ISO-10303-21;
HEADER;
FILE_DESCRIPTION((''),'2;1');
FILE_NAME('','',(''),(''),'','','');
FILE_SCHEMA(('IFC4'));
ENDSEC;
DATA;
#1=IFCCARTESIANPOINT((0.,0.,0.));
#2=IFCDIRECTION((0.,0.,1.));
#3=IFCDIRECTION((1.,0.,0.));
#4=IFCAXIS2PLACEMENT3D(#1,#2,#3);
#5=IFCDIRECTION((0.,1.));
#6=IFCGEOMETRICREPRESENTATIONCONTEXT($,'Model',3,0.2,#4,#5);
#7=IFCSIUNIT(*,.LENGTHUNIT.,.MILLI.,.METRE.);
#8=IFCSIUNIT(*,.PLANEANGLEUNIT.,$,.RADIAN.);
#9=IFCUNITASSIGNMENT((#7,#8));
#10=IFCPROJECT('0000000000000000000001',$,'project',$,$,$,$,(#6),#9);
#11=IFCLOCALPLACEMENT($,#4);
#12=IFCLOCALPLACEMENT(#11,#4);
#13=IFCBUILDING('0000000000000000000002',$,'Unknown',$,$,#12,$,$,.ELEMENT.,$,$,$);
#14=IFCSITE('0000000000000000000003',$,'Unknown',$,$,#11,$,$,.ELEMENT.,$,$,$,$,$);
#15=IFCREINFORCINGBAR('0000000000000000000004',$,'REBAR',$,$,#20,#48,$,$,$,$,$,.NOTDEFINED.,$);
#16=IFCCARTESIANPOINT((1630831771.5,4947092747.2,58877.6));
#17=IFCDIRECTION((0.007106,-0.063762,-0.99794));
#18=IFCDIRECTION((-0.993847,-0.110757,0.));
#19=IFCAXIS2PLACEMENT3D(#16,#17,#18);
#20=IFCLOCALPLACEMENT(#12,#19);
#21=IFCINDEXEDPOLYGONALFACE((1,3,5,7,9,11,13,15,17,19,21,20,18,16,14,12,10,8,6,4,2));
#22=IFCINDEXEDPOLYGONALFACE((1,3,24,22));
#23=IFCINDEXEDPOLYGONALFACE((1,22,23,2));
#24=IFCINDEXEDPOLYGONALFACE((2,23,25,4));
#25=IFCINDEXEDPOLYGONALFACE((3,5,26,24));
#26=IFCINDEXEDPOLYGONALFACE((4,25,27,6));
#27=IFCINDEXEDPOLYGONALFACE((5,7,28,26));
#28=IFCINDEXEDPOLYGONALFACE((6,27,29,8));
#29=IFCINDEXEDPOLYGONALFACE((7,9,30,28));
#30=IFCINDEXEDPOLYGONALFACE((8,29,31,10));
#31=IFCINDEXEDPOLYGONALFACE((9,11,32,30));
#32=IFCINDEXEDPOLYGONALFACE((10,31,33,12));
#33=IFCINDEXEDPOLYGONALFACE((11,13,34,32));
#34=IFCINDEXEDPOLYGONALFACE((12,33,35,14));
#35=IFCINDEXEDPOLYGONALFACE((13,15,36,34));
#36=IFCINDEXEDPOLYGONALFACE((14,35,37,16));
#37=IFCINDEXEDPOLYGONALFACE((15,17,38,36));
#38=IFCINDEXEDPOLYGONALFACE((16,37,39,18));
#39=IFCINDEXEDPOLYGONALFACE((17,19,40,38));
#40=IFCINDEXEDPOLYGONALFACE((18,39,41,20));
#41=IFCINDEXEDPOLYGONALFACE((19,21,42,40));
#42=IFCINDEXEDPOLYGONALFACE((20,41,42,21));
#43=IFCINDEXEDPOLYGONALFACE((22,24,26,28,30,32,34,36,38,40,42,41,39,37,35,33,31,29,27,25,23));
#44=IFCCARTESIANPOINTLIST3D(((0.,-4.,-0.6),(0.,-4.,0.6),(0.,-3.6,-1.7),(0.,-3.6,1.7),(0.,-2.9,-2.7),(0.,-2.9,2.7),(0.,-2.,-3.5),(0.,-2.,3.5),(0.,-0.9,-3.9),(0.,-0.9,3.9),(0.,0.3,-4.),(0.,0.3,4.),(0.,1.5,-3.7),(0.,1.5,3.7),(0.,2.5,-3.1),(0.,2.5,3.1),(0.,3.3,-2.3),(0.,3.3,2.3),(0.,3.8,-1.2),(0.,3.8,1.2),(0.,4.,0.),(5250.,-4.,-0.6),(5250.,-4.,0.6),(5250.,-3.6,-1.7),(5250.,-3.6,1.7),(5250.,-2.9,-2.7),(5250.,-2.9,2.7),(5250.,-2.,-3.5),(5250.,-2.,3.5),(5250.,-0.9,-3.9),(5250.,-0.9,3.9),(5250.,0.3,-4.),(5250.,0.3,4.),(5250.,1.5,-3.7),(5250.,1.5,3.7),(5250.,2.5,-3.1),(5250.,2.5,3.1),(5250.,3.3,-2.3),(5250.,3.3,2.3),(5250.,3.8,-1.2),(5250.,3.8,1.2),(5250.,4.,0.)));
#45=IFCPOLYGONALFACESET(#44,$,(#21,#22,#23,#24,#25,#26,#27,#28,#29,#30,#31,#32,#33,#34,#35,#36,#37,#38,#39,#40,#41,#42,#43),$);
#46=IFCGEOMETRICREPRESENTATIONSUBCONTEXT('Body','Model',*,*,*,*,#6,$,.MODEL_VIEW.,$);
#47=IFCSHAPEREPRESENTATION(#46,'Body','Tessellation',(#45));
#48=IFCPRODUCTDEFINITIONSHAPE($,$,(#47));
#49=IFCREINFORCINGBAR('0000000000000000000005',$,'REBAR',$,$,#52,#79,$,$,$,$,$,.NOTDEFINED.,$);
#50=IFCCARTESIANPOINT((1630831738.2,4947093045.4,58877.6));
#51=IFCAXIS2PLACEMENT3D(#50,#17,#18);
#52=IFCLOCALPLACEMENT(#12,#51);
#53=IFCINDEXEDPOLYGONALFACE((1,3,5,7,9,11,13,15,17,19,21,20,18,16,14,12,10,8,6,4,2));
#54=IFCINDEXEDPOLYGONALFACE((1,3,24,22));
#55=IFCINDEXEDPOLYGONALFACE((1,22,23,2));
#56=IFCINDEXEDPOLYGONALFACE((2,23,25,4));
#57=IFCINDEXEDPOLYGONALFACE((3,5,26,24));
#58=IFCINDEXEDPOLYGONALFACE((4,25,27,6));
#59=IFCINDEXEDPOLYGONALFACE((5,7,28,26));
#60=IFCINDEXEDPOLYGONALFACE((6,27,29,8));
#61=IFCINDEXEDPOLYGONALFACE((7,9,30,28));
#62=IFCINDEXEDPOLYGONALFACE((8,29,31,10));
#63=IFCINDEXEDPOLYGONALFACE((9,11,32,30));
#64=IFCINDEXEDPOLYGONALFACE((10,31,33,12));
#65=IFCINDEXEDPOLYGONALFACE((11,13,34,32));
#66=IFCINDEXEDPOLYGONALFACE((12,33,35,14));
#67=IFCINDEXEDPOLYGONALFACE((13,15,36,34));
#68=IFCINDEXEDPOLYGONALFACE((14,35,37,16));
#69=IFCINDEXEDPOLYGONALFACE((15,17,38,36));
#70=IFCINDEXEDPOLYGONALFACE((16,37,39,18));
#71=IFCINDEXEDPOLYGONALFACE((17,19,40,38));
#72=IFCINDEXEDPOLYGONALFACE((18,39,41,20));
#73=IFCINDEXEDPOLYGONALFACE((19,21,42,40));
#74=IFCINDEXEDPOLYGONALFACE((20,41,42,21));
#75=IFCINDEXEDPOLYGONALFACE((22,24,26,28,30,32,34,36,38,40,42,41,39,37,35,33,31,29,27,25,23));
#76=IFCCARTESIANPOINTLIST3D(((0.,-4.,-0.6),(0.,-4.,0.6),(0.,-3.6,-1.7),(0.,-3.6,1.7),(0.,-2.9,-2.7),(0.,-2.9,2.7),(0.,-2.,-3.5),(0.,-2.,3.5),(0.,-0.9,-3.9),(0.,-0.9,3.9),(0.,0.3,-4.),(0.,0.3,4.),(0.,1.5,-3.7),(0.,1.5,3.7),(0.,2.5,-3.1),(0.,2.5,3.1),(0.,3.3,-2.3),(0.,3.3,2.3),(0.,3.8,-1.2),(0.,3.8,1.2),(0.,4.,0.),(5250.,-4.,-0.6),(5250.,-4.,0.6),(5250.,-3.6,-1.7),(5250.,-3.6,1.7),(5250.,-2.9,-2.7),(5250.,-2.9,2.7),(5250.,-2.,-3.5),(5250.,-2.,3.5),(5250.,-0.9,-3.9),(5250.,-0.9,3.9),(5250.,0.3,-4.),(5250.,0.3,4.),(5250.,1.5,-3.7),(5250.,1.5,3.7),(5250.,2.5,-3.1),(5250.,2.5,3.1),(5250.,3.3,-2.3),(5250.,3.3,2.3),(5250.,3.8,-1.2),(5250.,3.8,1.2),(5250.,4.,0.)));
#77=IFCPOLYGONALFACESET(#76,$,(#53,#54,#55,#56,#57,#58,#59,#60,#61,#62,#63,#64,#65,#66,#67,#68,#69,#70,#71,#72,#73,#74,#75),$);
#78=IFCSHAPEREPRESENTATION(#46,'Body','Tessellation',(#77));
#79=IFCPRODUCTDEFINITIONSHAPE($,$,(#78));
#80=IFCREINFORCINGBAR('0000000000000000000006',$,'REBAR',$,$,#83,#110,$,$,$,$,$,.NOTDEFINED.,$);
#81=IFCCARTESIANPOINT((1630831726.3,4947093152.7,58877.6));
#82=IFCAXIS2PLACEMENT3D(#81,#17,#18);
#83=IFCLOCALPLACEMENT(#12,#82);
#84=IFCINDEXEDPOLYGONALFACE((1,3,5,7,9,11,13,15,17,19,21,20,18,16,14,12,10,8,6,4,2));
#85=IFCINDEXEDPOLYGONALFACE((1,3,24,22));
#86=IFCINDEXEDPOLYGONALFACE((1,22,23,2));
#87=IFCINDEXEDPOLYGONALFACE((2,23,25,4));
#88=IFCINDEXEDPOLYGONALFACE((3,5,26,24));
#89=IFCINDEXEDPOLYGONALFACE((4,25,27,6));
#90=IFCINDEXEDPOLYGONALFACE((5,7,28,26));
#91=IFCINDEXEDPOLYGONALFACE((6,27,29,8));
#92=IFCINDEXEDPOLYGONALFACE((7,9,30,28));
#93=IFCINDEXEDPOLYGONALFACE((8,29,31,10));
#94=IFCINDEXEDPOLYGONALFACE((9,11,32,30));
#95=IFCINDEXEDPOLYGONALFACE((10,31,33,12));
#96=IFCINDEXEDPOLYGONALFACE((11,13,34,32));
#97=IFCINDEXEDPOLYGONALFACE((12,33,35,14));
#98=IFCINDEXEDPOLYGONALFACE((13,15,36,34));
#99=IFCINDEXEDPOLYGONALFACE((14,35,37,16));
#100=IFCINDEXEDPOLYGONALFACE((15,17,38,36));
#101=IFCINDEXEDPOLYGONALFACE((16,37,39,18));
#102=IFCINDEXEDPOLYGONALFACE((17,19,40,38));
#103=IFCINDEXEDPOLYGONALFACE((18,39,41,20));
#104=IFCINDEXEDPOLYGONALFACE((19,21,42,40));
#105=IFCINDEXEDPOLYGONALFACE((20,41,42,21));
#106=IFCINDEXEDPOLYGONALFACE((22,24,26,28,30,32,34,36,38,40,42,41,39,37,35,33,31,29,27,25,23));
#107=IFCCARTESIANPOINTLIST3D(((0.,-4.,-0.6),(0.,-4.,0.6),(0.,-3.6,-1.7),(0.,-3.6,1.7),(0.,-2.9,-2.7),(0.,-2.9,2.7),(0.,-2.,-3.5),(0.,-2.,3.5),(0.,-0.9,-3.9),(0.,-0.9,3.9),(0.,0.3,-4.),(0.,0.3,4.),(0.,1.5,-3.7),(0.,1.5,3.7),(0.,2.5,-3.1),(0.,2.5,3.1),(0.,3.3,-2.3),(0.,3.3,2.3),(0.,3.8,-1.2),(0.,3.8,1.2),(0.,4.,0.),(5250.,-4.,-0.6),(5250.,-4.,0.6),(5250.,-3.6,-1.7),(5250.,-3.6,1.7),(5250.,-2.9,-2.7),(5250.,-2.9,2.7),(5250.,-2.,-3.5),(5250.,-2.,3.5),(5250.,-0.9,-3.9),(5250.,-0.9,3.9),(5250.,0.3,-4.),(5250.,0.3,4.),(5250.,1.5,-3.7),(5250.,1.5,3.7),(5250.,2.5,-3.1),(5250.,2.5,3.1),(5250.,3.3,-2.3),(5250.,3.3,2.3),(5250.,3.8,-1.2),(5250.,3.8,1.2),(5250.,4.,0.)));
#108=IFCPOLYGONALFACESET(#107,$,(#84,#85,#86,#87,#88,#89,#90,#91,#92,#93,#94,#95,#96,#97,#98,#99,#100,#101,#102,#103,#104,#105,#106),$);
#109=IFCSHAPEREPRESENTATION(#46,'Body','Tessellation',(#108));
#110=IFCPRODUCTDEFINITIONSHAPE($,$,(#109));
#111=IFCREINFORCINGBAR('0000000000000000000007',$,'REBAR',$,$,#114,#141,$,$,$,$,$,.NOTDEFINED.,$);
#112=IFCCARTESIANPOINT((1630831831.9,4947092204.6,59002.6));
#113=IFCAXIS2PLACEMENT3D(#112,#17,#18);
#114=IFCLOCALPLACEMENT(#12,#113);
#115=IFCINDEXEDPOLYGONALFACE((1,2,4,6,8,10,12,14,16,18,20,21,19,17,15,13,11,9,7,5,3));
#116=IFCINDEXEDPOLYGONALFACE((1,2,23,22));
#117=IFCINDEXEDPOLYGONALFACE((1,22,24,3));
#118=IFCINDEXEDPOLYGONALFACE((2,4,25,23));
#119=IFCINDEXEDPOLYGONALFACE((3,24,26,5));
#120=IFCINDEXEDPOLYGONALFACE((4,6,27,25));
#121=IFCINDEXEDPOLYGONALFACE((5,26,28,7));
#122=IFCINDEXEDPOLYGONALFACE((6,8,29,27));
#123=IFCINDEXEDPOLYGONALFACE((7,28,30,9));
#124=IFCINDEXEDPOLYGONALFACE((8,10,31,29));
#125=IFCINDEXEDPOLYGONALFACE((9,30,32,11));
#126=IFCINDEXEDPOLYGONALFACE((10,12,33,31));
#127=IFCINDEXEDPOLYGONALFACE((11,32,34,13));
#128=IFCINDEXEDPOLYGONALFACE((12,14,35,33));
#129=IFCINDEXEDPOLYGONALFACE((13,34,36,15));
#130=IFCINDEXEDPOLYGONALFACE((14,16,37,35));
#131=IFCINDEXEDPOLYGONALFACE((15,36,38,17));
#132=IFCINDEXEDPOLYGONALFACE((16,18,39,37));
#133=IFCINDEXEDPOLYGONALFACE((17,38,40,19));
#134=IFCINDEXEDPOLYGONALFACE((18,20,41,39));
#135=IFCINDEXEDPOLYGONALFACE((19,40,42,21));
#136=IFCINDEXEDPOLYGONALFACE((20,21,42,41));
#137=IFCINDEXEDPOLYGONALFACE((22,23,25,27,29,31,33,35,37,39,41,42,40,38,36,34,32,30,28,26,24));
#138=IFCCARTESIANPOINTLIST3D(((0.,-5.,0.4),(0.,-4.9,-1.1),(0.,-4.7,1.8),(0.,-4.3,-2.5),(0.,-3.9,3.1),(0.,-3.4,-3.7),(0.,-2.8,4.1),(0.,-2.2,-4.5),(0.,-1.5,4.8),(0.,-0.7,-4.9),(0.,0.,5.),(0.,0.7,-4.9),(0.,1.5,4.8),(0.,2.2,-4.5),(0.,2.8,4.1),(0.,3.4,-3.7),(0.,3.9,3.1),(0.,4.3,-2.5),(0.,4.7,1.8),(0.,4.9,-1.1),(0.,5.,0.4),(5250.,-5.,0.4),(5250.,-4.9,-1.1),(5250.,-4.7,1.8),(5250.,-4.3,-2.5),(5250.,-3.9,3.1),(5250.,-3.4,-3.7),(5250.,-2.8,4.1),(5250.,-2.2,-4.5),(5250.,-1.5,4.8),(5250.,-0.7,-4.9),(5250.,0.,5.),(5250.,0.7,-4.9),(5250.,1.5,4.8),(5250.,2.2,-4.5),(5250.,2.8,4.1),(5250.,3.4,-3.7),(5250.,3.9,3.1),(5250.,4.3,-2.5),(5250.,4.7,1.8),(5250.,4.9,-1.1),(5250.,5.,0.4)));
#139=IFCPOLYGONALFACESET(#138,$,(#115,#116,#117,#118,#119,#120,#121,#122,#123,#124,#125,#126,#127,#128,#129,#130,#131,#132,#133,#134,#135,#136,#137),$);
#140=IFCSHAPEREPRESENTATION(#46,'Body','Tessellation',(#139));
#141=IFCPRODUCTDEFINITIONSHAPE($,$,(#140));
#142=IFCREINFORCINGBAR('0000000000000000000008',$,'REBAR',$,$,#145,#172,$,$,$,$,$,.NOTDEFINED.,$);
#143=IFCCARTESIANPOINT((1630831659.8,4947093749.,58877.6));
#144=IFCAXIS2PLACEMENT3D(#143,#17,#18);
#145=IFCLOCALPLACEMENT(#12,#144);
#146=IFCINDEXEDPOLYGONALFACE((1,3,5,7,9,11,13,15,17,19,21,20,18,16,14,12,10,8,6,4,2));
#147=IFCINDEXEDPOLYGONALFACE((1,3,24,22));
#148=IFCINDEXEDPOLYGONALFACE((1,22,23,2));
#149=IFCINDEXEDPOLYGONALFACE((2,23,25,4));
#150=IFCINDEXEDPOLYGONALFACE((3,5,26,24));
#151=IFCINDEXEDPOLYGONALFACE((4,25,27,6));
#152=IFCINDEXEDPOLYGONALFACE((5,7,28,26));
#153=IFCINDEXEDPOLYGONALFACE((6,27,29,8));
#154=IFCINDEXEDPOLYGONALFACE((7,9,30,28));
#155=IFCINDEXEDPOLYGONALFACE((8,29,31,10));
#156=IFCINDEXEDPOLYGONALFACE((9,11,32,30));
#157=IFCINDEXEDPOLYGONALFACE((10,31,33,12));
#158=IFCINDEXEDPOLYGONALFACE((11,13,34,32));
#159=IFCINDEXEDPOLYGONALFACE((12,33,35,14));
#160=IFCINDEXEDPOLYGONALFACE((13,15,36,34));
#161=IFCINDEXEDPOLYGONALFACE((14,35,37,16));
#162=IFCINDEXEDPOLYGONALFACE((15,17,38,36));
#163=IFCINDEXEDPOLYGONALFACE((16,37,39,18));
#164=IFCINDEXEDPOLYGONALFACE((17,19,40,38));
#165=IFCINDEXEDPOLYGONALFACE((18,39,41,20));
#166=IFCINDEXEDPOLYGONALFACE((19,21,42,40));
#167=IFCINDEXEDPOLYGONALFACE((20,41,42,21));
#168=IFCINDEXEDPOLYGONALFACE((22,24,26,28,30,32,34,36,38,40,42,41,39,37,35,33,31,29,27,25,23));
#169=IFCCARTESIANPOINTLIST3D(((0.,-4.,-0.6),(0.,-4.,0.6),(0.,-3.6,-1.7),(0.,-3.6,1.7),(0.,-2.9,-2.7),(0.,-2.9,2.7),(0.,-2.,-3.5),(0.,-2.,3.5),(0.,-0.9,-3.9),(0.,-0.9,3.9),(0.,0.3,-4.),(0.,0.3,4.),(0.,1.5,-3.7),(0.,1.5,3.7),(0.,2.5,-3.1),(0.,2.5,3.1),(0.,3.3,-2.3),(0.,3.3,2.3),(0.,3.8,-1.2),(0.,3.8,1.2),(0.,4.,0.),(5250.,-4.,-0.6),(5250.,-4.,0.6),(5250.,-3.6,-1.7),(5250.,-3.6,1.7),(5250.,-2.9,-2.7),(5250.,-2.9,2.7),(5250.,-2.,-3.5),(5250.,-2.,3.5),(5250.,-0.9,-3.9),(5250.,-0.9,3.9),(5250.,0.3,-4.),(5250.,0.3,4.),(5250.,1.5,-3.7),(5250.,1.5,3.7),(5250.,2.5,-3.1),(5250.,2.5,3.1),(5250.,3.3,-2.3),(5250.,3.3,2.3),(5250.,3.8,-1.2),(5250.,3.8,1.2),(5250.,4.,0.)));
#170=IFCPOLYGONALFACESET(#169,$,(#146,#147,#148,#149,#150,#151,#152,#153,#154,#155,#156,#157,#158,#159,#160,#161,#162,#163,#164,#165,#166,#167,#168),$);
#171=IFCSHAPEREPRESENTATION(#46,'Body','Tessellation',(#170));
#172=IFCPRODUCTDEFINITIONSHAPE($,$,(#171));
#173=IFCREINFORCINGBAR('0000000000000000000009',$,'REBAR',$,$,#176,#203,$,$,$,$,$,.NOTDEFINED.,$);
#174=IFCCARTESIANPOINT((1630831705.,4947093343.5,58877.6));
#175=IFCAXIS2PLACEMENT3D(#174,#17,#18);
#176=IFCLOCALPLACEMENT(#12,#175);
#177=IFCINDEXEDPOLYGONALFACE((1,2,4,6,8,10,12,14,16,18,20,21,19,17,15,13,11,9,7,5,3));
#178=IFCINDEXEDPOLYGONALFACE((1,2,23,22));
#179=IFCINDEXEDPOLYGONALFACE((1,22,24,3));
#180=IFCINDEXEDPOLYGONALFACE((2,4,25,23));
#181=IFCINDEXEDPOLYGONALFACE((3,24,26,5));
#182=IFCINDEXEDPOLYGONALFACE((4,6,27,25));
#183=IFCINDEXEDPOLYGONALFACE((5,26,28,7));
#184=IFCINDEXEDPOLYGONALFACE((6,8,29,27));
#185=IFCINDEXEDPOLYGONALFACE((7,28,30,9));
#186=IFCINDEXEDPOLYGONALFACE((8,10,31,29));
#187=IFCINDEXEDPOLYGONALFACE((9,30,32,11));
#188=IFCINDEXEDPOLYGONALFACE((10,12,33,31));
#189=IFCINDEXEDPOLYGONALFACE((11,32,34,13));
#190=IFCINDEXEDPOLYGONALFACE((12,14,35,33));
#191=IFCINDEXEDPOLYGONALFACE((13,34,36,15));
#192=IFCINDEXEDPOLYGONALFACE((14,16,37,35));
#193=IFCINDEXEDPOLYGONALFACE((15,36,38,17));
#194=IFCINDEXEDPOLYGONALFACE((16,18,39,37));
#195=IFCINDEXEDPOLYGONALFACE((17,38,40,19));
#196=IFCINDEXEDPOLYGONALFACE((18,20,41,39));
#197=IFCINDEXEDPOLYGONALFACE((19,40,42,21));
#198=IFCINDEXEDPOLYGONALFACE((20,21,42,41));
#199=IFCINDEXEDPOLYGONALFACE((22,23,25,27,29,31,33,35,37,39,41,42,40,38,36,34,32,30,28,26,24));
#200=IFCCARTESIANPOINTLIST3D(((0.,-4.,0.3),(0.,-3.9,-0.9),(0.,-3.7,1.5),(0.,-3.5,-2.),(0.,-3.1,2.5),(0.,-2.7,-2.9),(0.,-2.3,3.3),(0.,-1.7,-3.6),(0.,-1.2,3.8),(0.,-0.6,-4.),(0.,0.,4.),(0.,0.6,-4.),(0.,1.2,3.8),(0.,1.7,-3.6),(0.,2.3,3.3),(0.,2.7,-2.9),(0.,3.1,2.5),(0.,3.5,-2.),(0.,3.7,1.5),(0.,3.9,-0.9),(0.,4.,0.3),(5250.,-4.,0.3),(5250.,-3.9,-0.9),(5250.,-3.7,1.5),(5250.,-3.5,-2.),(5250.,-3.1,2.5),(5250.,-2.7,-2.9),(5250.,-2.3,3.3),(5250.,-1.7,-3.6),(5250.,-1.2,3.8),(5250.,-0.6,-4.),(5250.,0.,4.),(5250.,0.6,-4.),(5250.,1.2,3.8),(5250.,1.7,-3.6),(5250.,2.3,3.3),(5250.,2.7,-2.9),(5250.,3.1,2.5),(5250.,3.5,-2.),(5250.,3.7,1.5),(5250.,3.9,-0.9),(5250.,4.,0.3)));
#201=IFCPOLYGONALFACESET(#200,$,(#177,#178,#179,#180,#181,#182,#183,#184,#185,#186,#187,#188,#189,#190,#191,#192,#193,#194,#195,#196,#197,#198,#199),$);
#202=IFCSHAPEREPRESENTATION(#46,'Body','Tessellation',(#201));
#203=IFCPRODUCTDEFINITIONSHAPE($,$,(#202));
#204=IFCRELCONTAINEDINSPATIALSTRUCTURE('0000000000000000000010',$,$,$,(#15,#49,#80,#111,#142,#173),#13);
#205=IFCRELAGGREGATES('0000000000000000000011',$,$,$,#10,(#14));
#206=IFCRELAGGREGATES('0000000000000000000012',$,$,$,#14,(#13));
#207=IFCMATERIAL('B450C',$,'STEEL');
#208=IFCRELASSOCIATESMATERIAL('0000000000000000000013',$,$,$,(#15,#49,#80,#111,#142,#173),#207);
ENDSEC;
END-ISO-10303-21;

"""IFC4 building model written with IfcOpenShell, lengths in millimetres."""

from ifc_helpers import new_model, entity, si_unit, direction, frame, origin_with_axes, place, context, subcontext, project, spatial, material, element, save


model = new_model("IFC4")

# Units and contexts
model_context = context("Model", 3, precision=0.2, world=origin_with_axes(), true_north=direction((0.0, 1.0)))
body_context = subcontext(model_context, "Body", "Model", "MODEL_VIEW")
ifc_project = project(units=[si_unit("LENGTHUNIT", "METRE", prefix="MILLI"), si_unit("PLANEANGLEUNIT", "RADIAN")], contexts=[model_context])

# Site, building
site_placement = place(None, origin_with_axes())
site = spatial("IfcSite", under=ifc_project, at=site_placement, Name="Unknown", CompositionType="ELEMENT")
building_placement = place(site_placement, origin_with_axes())
building = spatial("IfcBuilding", under=site, at=building_placement, Name="Unknown", CompositionType="ELEMENT")

# Reinforcing bars
ifc_material = material(Name="B450C", Category="STEEL")
reinforcing_bar_1_placement = place(building_placement, frame((1630831771.5, 4947092747.2, 58877.6), z_axis=(0.007106, -0.063762, -0.99794), x_axis=(-0.993847, -0.110757, 0.0)))
element("IfcReinforcingBar", 1, at=reinforcing_bar_1_placement, inside=building, material=ifc_material, Name="REBAR", PredefinedType="NOTDEFINED", context=body_context, shape_type="AdvancedSweptSolid", body=[
    entity("IfcSweptDiskSolid", entity("IfcIndexedPolyCurve", entity("IfcCartesianPointList3D", [[0.0, 0.0, 0.0], [5250.0, 0.0, 0.0]]), [entity("IfcLineIndex", [1, 2])]), 4.0),
])
reinforcing_bar_2_placement = place(building_placement, frame((1630831738.2, 4947093045.4, 58877.6), z_axis=(0.007106, -0.063762, -0.99794), x_axis=(-0.993847, -0.110757, 0.0)))
element("IfcReinforcingBar", 2, at=reinforcing_bar_2_placement, inside=building, material=ifc_material, Name="REBAR", PredefinedType="NOTDEFINED", context=body_context, shape_type="AdvancedSweptSolid", body=[
    entity("IfcSweptDiskSolid", entity("IfcIndexedPolyCurve", entity("IfcCartesianPointList3D", [[0.0, 0.0, 0.0], [5250.0, 0.0, 0.0]]), [entity("IfcLineIndex", [1, 2])]), 4.0),
])
reinforcing_bar_3_placement = place(building_placement, frame((1630831726.3, 4947093152.7, 58877.6), z_axis=(0.007106, -0.063762, -0.99794), x_axis=(-0.993847, -0.110757, 0.0)))
element("IfcReinforcingBar", 3, at=reinforcing_bar_3_placement, inside=building, material=ifc_material, Name="REBAR", PredefinedType="NOTDEFINED", context=body_context, shape_type="AdvancedSweptSolid", body=[
    entity("IfcSweptDiskSolid", entity("IfcIndexedPolyCurve", entity("IfcCartesianPointList3D", [[0.0, 0.0, 0.0], [5250.0, 0.0, 0.0]]), [entity("IfcLineIndex", [1, 2])]), 4.0),
])
reinforcing_bar_4_placement = place(building_placement, frame((1630831831.9, 4947092204.6, 59002.6), z_axis=(0.007106, -0.063762, -0.99794), x_axis=(-0.993847, -0.110757, 0.0)))
element("IfcReinforcingBar", 4, at=reinforcing_bar_4_placement, inside=building, material=ifc_material, Name="REBAR", PredefinedType="NOTDEFINED", context=body_context, shape_type="AdvancedSweptSolid", body=[
    entity("IfcSweptDiskSolid", entity("IfcIndexedPolyCurve", entity("IfcCartesianPointList3D", [[0.0, 0.0, 0.0], [5250.0, 0.0, 0.0]]), [entity("IfcLineIndex", [1, 2])]), 5.0),
])
for number, where, z_axis, x_axis, name in (
    (5, (1630831659.8, 4947093749.0, 58877.6), (0.007106, -0.063762, -0.99794), (-0.993847, -0.110757, 0.0), "REBAR"),
):
    element("IfcReinforcingBar", number, at=place(building_placement, frame(where, z_axis=z_axis, x_axis=x_axis)), inside=building, material=ifc_material, Name=name, PredefinedType="NOTDEFINED", context=body_context, shape_type="AdvancedSweptSolid", body=[
        entity("IfcSweptDiskSolid", entity("IfcIndexedPolyCurve", entity("IfcCartesianPointList3D", [[0.0, 0.0, 0.0], [5250.0, 0.0, 0.0]]), [entity("IfcLineIndex", [1, 2])]), 4.0),
    ])
reinforcing_bar_5_placement = place(building_placement, frame((1630831705.0, 4947093343.5, 58877.6), z_axis=(0.007106, -0.063762, -0.99794), x_axis=(-0.993847, -0.110757, 0.0)))
element("IfcReinforcingBar", 6, at=reinforcing_bar_5_placement, inside=building, material=ifc_material, Name="REBAR", PredefinedType="NOTDEFINED", context=body_context, shape_type="AdvancedSweptSolid", body=[
    entity("IfcSweptDiskSolid", entity("IfcIndexedPolyCurve", entity("IfcCartesianPointList3D", [[0.0, 0.0, 0.0], [5250.0, 0.0, 0.0]]), [entity("IfcLineIndex", [1, 2])]), 4.0),
])

save(model, "model.ifc")
